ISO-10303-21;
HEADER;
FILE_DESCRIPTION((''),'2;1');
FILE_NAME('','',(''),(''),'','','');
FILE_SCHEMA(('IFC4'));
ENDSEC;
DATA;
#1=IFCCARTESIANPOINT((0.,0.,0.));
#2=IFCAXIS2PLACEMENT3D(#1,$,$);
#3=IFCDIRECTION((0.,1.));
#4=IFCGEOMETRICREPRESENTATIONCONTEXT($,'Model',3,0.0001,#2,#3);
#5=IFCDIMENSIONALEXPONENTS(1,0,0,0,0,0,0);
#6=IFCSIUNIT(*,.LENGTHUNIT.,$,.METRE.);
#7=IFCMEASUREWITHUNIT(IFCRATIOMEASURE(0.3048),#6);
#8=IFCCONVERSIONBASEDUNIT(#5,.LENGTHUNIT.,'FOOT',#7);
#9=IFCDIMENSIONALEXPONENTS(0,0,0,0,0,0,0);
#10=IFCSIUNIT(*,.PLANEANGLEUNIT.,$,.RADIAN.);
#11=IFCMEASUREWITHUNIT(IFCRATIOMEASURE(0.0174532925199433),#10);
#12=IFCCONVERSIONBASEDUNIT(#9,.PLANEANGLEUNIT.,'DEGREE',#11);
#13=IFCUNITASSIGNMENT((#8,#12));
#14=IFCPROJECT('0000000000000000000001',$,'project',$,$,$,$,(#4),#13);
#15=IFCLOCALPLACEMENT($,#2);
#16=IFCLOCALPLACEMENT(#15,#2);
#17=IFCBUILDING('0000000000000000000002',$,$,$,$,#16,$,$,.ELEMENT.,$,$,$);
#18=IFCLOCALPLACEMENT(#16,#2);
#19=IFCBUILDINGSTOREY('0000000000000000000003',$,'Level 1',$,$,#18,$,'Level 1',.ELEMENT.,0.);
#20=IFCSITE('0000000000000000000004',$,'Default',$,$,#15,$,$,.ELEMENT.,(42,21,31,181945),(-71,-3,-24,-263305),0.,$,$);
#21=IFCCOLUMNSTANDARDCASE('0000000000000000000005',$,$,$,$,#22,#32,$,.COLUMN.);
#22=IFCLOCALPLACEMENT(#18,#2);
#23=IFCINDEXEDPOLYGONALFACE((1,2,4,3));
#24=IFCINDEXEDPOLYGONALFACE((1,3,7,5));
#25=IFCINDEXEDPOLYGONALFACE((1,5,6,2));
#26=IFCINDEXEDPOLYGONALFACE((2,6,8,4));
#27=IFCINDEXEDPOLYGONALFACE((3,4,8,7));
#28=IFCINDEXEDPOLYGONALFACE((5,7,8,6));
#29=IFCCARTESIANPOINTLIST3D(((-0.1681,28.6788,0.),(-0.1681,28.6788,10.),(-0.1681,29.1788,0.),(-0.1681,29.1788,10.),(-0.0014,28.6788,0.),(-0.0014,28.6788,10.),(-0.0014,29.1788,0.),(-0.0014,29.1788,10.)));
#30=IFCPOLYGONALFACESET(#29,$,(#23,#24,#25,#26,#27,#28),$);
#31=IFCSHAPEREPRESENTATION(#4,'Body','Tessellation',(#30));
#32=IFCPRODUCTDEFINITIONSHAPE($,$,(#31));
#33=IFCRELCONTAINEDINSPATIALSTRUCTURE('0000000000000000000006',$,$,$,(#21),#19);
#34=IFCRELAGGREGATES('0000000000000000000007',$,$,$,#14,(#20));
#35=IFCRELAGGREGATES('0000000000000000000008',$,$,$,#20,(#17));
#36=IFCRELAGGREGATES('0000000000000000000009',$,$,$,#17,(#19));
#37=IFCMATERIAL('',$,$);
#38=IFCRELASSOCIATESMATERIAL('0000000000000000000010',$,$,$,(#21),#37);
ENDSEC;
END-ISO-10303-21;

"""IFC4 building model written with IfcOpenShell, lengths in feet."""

from ifc_helpers import new_model, entity, si_unit, converted_unit, direction, frame, origin, place, context, project, spatial, rectangle, extrude, material, element, save


model = new_model("IFC4")

# Units and contexts
model_context = context("Model", 3, precision=0.0001, world=origin(), true_north=direction((0.0, 1.0)))
ifc_project = project(units=[converted_unit("LENGTHUNIT", "FOOT", entity("IfcRatioMeasure", 0.3048), si_unit("LENGTHUNIT", "METRE"), dimensions=[1, 0, 0, 0, 0, 0, 0]), converted_unit("PLANEANGLEUNIT", "DEGREE", entity("IfcRatioMeasure", 0.0174532925199433), si_unit("PLANEANGLEUNIT", "RADIAN"), dimensions=[0, 0, 0, 0, 0, 0, 0])], contexts=[model_context])

# Site, building, storey
site_placement = place(None, origin())
site = spatial("IfcSite", under=ifc_project, at=site_placement, Name="Default", CompositionType="ELEMENT", RefLatitude=(42, 21, 31, 181945), RefLongitude=(-71, -3, -24, -263305), RefElevation=0.0)
building_placement = place(site_placement, origin())
building = spatial("IfcBuilding", under=site, at=building_placement, CompositionType="ELEMENT")
storey_placement = place(building_placement, origin())
storey = spatial("IfcBuildingStorey", under=building, at=storey_placement, Name="Level 1", LongName="Level 1", CompositionType="ELEMENT", Elevation=0.0)

# Column
ifc_material_1 = material(Name="")
wall_placement = place(storey_placement, frame((-0.1681, 28.9288, 0.0)))
column_placement = place(wall_placement, frame((0.0833, 0.0, 0.0), z_axis=(0.0, 0.0, 1.0), x_axis=(1.0, 0.0, 0.0)))
element("IfcColumnStandardCase", 1, at=column_placement, inside=storey, material=ifc_material_1, PredefinedType="COLUMN", context=model_context, shape_type="SweptSolid", body=[
    extrude(rectangle(XDim=0.1667, YDim=0.5), origin(), (0.0, 0.0, 1.0), 10.0),
])

save(model, "model.ifc")
